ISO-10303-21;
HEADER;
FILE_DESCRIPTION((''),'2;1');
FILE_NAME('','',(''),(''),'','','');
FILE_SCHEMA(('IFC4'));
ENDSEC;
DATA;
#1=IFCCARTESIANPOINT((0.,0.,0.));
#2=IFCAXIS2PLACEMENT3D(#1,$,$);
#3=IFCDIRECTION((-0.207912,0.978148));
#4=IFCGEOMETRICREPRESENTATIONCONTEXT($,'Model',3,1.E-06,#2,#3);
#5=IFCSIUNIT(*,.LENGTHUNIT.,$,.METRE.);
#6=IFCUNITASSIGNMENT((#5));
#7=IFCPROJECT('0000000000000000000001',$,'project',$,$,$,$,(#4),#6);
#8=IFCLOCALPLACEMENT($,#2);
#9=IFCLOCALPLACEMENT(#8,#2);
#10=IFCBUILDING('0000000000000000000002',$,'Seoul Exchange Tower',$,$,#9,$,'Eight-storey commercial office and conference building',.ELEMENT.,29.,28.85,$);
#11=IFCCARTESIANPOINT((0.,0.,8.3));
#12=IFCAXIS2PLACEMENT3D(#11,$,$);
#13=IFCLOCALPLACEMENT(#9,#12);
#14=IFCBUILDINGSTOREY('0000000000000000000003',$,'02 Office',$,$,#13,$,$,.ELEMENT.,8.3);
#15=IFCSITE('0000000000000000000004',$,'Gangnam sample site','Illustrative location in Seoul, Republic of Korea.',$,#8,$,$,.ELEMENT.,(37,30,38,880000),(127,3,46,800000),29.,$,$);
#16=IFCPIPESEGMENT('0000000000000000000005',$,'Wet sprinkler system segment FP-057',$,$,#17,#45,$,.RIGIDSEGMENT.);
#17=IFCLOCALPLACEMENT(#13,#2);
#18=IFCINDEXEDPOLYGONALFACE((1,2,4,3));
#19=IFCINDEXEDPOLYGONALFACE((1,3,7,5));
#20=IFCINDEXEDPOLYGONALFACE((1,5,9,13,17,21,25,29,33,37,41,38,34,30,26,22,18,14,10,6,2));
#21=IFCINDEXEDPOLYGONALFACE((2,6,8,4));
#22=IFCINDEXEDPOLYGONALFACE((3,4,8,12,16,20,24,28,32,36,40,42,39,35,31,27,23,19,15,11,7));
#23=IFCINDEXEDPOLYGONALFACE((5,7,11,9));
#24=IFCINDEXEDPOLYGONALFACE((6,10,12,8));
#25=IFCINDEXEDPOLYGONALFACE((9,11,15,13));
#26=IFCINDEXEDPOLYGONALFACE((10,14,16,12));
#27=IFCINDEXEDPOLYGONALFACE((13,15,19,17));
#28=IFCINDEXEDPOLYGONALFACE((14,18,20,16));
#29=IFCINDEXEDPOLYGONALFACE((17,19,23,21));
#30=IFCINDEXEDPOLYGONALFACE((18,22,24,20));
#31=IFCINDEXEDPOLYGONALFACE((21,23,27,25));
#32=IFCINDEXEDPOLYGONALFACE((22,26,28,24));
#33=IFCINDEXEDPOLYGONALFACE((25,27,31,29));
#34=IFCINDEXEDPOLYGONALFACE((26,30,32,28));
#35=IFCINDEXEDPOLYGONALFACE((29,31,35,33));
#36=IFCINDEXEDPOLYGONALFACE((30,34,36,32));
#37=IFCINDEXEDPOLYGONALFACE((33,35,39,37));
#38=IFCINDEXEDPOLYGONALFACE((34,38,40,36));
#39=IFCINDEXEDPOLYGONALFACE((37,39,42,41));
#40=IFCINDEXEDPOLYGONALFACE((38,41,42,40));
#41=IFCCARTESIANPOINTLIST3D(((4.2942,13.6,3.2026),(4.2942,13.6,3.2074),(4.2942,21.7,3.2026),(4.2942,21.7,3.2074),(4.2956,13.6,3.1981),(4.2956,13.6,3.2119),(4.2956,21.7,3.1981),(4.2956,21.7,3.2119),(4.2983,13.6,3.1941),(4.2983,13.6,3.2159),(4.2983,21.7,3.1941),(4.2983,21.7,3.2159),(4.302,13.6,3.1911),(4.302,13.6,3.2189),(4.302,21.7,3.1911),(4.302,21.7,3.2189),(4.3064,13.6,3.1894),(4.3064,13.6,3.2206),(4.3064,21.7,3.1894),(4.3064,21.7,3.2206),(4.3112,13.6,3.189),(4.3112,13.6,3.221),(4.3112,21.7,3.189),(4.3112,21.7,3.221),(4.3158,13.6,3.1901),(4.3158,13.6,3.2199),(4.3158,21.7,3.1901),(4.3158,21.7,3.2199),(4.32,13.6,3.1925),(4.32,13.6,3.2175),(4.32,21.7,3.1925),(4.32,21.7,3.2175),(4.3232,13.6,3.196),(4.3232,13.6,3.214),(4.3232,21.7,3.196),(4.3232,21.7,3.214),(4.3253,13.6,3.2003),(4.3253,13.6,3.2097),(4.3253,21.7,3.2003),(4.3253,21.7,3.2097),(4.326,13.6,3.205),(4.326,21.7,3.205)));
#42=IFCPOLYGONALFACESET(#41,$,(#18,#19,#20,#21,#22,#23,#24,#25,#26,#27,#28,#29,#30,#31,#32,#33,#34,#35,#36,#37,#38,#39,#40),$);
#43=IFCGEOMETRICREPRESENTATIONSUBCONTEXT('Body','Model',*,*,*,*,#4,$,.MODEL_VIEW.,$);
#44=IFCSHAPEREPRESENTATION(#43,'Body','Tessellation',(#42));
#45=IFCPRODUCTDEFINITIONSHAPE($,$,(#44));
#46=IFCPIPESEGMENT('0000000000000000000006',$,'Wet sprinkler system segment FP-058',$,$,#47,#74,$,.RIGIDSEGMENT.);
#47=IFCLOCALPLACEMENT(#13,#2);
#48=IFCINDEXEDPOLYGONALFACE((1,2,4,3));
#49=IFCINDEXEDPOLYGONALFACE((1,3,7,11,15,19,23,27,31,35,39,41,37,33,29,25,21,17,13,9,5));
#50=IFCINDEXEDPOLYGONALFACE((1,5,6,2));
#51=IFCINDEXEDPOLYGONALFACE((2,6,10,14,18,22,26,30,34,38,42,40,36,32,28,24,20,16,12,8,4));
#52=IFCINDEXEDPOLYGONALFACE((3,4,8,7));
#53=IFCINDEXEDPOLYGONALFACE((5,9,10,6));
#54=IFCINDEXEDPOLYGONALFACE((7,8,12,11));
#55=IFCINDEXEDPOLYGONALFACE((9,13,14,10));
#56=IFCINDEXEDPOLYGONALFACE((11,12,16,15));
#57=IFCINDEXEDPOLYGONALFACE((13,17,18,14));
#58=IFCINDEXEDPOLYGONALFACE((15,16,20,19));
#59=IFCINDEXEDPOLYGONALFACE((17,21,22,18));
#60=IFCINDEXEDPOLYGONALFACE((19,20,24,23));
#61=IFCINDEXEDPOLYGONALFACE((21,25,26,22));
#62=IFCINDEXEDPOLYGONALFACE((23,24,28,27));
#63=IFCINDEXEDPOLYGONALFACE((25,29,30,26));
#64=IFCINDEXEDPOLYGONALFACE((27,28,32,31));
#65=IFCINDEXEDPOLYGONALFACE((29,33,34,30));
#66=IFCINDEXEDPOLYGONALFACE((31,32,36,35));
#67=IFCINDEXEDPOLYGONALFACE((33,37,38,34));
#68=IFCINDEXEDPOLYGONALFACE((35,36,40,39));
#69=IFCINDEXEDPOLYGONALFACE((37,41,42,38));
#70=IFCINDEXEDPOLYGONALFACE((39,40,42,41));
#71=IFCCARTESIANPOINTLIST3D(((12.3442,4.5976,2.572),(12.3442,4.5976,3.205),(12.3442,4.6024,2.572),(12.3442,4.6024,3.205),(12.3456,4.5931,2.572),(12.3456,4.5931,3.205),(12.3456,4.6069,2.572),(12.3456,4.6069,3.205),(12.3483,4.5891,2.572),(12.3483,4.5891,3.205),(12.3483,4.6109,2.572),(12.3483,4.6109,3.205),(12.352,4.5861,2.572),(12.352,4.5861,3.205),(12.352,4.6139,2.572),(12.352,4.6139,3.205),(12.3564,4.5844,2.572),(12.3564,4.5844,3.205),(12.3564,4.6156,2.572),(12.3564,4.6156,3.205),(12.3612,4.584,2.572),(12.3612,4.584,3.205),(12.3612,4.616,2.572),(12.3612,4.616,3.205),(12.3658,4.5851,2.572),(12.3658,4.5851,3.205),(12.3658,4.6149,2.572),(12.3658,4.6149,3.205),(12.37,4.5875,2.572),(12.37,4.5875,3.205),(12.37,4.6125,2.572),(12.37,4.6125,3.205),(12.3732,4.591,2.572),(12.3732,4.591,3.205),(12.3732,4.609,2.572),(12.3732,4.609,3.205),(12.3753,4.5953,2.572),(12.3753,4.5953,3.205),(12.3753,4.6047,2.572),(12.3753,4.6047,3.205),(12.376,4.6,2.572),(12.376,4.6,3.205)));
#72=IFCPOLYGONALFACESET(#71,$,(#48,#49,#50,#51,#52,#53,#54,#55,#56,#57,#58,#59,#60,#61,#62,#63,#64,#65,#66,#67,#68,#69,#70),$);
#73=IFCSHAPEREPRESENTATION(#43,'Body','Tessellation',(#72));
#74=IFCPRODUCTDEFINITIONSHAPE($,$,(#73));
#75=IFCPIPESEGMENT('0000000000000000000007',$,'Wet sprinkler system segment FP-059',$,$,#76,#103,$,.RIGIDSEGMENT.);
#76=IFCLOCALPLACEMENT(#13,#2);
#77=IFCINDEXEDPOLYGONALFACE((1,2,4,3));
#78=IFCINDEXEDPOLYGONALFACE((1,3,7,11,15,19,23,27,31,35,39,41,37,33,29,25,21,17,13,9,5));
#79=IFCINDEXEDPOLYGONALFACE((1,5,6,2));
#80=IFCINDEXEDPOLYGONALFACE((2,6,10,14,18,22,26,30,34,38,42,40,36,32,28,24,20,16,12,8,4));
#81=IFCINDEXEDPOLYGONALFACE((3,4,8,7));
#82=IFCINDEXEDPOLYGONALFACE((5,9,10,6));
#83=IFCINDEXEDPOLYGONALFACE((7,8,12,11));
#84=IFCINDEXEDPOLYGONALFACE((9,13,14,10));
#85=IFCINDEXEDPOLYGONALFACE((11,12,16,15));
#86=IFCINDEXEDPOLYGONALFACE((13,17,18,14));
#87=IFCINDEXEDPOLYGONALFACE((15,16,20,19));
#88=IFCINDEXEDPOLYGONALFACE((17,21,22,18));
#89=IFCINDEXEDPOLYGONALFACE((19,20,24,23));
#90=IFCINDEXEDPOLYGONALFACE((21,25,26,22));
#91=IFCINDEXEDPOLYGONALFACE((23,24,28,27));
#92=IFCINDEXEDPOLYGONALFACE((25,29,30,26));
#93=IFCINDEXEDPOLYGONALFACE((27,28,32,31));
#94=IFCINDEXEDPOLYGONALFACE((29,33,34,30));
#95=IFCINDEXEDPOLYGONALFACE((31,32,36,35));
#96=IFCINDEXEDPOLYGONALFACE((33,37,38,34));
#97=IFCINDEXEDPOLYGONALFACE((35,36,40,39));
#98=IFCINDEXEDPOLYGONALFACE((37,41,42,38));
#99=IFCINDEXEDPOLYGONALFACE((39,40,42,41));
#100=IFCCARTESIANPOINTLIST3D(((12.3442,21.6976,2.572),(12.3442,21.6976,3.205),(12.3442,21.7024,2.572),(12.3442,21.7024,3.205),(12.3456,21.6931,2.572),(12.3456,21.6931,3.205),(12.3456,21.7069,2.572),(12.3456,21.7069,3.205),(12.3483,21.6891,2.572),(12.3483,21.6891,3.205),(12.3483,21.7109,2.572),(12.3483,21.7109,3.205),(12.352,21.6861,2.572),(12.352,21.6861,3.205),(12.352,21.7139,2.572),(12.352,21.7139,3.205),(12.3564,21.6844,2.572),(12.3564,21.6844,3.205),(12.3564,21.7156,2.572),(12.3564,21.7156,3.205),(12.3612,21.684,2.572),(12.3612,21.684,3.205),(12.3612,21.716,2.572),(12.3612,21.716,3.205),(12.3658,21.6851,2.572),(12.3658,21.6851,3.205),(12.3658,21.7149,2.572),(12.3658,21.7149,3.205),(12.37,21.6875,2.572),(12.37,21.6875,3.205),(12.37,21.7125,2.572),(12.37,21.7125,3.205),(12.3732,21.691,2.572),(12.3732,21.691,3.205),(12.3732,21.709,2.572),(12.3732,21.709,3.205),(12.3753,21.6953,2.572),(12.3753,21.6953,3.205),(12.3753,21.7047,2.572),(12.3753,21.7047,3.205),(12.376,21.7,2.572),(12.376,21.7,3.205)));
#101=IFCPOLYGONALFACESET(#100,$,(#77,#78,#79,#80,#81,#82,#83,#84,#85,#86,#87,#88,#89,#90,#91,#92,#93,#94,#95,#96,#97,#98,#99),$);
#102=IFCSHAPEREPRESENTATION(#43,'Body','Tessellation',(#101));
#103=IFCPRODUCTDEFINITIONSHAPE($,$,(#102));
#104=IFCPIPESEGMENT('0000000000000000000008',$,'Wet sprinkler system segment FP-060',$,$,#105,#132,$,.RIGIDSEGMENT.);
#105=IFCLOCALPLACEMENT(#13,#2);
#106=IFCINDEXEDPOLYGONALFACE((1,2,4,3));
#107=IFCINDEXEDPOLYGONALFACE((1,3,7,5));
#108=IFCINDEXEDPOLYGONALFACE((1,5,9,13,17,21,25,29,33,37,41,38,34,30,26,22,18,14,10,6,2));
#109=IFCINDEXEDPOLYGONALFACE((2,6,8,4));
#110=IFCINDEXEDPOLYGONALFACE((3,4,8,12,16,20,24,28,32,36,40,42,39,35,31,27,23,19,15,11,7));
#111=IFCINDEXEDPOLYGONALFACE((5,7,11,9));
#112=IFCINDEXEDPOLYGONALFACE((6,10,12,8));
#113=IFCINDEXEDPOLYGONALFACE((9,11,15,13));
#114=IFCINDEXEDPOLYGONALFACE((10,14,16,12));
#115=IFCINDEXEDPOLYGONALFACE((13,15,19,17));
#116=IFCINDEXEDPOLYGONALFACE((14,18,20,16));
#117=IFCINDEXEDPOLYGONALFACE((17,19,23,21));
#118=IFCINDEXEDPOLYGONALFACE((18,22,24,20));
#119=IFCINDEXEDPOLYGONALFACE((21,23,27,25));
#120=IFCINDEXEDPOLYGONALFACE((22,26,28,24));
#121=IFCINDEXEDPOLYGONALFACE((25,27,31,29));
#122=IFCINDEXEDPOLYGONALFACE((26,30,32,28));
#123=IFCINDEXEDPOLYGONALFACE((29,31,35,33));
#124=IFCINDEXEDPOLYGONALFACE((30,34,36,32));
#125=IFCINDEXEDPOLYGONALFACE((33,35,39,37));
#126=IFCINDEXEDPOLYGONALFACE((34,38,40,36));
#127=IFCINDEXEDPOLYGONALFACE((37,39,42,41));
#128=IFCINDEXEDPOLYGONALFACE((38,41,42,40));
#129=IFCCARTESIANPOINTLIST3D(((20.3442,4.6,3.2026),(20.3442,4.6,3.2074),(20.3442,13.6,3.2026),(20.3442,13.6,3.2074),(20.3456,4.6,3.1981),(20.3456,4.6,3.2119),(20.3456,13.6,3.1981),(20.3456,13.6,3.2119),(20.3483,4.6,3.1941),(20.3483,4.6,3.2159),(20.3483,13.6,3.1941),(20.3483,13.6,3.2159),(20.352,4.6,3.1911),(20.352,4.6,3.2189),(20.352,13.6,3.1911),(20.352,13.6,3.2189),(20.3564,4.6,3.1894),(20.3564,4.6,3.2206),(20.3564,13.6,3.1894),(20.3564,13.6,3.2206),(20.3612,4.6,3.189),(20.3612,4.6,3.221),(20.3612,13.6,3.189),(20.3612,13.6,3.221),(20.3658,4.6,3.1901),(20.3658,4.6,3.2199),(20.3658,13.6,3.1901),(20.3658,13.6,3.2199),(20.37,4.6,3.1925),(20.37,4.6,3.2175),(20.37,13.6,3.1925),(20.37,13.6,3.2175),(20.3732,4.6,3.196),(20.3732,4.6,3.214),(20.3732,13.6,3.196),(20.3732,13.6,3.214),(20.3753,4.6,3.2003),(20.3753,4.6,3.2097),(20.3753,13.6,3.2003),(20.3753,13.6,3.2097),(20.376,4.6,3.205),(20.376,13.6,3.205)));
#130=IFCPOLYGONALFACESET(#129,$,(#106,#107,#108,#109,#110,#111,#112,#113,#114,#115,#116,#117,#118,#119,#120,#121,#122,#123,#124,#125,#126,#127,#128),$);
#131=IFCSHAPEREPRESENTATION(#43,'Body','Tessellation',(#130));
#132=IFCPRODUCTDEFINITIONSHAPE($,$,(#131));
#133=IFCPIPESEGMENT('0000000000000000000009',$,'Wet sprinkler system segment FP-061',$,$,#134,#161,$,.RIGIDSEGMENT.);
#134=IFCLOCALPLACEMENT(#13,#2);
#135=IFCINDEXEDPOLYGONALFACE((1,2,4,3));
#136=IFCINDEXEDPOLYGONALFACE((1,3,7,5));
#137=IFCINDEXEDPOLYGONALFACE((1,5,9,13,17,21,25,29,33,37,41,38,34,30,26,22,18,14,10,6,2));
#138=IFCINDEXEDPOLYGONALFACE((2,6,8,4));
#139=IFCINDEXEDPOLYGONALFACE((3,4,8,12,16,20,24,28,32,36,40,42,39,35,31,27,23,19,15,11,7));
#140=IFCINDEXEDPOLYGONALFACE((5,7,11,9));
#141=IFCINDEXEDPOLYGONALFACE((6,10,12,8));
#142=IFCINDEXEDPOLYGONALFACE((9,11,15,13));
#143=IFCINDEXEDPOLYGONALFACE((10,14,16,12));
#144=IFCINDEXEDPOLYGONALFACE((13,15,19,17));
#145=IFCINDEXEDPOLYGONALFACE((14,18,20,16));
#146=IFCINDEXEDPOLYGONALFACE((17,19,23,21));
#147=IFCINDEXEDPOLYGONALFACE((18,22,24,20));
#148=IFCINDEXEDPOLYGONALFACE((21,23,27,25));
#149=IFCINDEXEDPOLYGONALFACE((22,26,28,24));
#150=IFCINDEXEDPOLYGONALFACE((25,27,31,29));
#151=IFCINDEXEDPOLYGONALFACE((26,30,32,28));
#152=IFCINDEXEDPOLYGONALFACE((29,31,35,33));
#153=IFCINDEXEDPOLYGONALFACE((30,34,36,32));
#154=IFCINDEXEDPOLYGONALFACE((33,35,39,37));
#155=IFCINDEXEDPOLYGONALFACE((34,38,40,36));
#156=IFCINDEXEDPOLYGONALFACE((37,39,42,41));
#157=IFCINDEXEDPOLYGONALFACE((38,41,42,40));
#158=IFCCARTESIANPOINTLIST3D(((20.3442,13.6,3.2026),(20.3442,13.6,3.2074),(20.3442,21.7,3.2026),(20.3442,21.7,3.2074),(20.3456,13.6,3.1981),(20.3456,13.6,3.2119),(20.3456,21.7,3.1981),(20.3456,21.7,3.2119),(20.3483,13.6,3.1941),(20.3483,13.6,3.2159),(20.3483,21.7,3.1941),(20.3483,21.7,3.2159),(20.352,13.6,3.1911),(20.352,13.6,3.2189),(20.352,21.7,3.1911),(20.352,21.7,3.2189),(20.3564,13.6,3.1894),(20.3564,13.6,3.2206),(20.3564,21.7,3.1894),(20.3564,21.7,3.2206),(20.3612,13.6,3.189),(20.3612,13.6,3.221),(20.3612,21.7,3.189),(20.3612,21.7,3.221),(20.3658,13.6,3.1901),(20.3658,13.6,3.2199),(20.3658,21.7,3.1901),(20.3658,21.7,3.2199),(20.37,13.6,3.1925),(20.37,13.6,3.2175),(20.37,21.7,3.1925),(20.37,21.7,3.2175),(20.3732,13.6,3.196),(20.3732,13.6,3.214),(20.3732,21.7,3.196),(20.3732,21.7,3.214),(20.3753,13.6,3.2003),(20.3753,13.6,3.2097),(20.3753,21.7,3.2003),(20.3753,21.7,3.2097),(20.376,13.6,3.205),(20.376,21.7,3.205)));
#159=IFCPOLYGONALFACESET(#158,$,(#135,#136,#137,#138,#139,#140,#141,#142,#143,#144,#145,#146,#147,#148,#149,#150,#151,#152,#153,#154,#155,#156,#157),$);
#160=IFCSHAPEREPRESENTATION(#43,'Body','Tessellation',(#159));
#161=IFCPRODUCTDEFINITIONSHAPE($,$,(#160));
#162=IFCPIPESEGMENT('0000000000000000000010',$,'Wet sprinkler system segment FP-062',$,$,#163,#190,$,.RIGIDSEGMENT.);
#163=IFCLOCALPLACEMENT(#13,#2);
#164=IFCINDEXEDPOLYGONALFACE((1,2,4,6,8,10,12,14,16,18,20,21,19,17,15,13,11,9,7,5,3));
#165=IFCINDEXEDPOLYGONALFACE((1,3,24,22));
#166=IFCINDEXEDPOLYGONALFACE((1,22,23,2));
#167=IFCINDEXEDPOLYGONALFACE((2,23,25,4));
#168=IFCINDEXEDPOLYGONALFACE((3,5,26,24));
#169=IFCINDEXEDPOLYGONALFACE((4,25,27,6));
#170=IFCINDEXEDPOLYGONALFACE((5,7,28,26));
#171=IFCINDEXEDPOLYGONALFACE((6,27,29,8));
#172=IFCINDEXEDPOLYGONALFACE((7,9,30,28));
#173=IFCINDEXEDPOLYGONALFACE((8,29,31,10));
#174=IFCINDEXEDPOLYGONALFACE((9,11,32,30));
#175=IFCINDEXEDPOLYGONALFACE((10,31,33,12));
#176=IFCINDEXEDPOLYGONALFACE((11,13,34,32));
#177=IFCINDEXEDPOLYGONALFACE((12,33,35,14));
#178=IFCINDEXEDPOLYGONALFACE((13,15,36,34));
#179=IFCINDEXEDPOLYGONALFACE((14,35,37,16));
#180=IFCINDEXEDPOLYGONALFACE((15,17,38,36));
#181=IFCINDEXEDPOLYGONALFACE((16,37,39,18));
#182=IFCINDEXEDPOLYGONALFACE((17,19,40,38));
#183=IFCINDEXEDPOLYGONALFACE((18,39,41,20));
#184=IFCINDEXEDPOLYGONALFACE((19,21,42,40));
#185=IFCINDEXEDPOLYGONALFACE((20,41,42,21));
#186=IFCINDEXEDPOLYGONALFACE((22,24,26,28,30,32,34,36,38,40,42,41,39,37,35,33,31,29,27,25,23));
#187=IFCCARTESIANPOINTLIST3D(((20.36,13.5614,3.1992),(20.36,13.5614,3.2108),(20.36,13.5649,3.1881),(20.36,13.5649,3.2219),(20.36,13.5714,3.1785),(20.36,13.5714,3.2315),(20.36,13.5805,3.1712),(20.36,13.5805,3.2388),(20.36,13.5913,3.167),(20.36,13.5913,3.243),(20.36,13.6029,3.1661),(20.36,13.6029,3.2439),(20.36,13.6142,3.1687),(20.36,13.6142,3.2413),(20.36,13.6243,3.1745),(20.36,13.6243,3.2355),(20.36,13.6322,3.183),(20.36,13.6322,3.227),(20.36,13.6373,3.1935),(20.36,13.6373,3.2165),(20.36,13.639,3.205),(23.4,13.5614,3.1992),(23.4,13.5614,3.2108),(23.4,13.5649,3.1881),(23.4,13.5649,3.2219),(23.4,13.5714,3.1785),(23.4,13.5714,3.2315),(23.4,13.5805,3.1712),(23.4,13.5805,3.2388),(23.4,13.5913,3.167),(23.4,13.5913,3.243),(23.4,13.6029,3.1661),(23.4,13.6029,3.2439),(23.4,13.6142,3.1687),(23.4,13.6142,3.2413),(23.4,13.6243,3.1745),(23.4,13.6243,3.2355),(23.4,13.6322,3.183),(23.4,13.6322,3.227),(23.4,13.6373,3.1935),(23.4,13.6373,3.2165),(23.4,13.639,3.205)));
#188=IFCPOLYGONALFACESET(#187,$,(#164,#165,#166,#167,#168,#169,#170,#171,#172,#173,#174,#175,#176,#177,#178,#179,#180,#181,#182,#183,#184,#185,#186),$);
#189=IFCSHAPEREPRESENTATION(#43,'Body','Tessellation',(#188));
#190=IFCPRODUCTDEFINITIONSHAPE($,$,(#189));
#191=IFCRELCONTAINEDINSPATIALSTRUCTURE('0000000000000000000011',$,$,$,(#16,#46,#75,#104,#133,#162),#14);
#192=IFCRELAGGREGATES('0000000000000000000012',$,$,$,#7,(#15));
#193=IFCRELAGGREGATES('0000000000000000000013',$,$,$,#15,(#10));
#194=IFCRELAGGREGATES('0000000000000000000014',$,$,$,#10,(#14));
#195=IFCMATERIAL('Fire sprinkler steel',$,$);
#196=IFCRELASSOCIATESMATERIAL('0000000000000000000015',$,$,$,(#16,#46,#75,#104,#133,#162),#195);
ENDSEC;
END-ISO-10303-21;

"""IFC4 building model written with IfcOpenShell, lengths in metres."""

from ifc_helpers import new_model, si_unit, direction, frame, origin, place, context, subcontext, project, spatial, circle, extrude, material, element, save


model = new_model("IFC4")

# Units and contexts
model_context = context("Model", 3, precision=1e-06, world=origin(), true_north=direction((-0.207912, 0.978148)))
body_context = subcontext(model_context, "Body", "Model", "MODEL_VIEW")
ifc_project = project(units=[si_unit("LENGTHUNIT", "METRE")], contexts=[model_context])

# Site, building, storey
site_placement = place(None, origin())
site = spatial("IfcSite", under=ifc_project, at=site_placement, Name="Gangnam sample site", Description="Illustrative location in Seoul, Republic of Korea.", CompositionType="ELEMENT", RefLatitude=(37, 30, 38, 880000), RefLongitude=(127, 3, 46, 800000), RefElevation=29.0)
building_placement = place(site_placement, origin())
building = spatial("IfcBuilding", under=site, at=building_placement, Name="Seoul Exchange Tower", LongName="Eight-storey commercial office and conference building", CompositionType="ELEMENT", ElevationOfRefHeight=29.0, ElevationOfTerrain=28.85)
storey_placement = place(building_placement, frame((0.0, 0.0, 8.3)))
storey = spatial("IfcBuildingStorey", under=building, at=storey_placement, Name="02 Office", CompositionType="ELEMENT", Elevation=8.3)

# Shared definitions
ifc_material = material(Name="Fire sprinkler steel")
placement = place(storey_placement, origin())

# Pipe segments
element("IfcPipeSegment", 1, at=placement, inside=storey, material=ifc_material, Name="Wet sprinkler system segment FP-057", PredefinedType="RIGIDSEGMENT", context=body_context, shape_type="SweptSolid", body=[
    extrude(circle(Radius=0.016), frame((4.31, 13.6, 3.205), z_axis=(0.0, 1.0, 0.0), x_axis=(1.0, 0.0, 0.0)), (0.0, 0.0, 1.0), 8.1),
])
element("IfcPipeSegment", 2, at=placement, inside=storey, material=ifc_material, Name="Wet sprinkler system segment FP-058", PredefinedType="RIGIDSEGMENT", context=body_context, shape_type="SweptSolid", body=[
    extrude(circle(Radius=0.016), frame((12.36, 4.6, 3.205), z_axis=(0.0, 0.0, -1.0), x_axis=(1.0, 0.0, 0.0)), (0.0, 0.0, 1.0), 0.633),
])
element("IfcPipeSegment", 3, at=placement, inside=storey, material=ifc_material, Name="Wet sprinkler system segment FP-059", PredefinedType="RIGIDSEGMENT", context=body_context, shape_type="SweptSolid", body=[
    extrude(circle(Radius=0.016), frame((12.36, 21.7, 3.205), z_axis=(0.0, 0.0, -1.0), x_axis=(1.0, 0.0, 0.0)), (0.0, 0.0, 1.0), 0.633),
])
element("IfcPipeSegment", 4, at=placement, inside=storey, material=ifc_material, Name="Wet sprinkler system segment FP-060", PredefinedType="RIGIDSEGMENT", context=body_context, shape_type="SweptSolid", body=[
    extrude(circle(Radius=0.016), frame((20.36, 13.6, 3.205), z_axis=(0.0, -1.0, 0.0), x_axis=(1.0, 0.0, 0.0)), (0.0, 0.0, 1.0), 9.0),
])
element("IfcPipeSegment", 5, at=placement, inside=storey, material=ifc_material, Name="Wet sprinkler system segment FP-061", PredefinedType="RIGIDSEGMENT", context=body_context, shape_type="SweptSolid", body=[
    extrude(circle(Radius=0.016), frame((20.36, 13.6, 3.205), z_axis=(0.0, 1.0, 0.0), x_axis=(1.0, 0.0, 0.0)), (0.0, 0.0, 1.0), 8.1),
])
element("IfcPipeSegment", 6, at=placement, inside=storey, material=ifc_material, Name="Wet sprinkler system segment FP-062", PredefinedType="RIGIDSEGMENT", context=body_context, shape_type="SweptSolid", body=[
    extrude(circle(Radius=0.039), frame((20.36, 13.6, 3.205), z_axis=(1.0, 0.0, 0.0), x_axis=(0.0, 1.0, 0.0)), (0.0, 0.0, 1.0), 3.04),
])

save(model, "model.ifc")
